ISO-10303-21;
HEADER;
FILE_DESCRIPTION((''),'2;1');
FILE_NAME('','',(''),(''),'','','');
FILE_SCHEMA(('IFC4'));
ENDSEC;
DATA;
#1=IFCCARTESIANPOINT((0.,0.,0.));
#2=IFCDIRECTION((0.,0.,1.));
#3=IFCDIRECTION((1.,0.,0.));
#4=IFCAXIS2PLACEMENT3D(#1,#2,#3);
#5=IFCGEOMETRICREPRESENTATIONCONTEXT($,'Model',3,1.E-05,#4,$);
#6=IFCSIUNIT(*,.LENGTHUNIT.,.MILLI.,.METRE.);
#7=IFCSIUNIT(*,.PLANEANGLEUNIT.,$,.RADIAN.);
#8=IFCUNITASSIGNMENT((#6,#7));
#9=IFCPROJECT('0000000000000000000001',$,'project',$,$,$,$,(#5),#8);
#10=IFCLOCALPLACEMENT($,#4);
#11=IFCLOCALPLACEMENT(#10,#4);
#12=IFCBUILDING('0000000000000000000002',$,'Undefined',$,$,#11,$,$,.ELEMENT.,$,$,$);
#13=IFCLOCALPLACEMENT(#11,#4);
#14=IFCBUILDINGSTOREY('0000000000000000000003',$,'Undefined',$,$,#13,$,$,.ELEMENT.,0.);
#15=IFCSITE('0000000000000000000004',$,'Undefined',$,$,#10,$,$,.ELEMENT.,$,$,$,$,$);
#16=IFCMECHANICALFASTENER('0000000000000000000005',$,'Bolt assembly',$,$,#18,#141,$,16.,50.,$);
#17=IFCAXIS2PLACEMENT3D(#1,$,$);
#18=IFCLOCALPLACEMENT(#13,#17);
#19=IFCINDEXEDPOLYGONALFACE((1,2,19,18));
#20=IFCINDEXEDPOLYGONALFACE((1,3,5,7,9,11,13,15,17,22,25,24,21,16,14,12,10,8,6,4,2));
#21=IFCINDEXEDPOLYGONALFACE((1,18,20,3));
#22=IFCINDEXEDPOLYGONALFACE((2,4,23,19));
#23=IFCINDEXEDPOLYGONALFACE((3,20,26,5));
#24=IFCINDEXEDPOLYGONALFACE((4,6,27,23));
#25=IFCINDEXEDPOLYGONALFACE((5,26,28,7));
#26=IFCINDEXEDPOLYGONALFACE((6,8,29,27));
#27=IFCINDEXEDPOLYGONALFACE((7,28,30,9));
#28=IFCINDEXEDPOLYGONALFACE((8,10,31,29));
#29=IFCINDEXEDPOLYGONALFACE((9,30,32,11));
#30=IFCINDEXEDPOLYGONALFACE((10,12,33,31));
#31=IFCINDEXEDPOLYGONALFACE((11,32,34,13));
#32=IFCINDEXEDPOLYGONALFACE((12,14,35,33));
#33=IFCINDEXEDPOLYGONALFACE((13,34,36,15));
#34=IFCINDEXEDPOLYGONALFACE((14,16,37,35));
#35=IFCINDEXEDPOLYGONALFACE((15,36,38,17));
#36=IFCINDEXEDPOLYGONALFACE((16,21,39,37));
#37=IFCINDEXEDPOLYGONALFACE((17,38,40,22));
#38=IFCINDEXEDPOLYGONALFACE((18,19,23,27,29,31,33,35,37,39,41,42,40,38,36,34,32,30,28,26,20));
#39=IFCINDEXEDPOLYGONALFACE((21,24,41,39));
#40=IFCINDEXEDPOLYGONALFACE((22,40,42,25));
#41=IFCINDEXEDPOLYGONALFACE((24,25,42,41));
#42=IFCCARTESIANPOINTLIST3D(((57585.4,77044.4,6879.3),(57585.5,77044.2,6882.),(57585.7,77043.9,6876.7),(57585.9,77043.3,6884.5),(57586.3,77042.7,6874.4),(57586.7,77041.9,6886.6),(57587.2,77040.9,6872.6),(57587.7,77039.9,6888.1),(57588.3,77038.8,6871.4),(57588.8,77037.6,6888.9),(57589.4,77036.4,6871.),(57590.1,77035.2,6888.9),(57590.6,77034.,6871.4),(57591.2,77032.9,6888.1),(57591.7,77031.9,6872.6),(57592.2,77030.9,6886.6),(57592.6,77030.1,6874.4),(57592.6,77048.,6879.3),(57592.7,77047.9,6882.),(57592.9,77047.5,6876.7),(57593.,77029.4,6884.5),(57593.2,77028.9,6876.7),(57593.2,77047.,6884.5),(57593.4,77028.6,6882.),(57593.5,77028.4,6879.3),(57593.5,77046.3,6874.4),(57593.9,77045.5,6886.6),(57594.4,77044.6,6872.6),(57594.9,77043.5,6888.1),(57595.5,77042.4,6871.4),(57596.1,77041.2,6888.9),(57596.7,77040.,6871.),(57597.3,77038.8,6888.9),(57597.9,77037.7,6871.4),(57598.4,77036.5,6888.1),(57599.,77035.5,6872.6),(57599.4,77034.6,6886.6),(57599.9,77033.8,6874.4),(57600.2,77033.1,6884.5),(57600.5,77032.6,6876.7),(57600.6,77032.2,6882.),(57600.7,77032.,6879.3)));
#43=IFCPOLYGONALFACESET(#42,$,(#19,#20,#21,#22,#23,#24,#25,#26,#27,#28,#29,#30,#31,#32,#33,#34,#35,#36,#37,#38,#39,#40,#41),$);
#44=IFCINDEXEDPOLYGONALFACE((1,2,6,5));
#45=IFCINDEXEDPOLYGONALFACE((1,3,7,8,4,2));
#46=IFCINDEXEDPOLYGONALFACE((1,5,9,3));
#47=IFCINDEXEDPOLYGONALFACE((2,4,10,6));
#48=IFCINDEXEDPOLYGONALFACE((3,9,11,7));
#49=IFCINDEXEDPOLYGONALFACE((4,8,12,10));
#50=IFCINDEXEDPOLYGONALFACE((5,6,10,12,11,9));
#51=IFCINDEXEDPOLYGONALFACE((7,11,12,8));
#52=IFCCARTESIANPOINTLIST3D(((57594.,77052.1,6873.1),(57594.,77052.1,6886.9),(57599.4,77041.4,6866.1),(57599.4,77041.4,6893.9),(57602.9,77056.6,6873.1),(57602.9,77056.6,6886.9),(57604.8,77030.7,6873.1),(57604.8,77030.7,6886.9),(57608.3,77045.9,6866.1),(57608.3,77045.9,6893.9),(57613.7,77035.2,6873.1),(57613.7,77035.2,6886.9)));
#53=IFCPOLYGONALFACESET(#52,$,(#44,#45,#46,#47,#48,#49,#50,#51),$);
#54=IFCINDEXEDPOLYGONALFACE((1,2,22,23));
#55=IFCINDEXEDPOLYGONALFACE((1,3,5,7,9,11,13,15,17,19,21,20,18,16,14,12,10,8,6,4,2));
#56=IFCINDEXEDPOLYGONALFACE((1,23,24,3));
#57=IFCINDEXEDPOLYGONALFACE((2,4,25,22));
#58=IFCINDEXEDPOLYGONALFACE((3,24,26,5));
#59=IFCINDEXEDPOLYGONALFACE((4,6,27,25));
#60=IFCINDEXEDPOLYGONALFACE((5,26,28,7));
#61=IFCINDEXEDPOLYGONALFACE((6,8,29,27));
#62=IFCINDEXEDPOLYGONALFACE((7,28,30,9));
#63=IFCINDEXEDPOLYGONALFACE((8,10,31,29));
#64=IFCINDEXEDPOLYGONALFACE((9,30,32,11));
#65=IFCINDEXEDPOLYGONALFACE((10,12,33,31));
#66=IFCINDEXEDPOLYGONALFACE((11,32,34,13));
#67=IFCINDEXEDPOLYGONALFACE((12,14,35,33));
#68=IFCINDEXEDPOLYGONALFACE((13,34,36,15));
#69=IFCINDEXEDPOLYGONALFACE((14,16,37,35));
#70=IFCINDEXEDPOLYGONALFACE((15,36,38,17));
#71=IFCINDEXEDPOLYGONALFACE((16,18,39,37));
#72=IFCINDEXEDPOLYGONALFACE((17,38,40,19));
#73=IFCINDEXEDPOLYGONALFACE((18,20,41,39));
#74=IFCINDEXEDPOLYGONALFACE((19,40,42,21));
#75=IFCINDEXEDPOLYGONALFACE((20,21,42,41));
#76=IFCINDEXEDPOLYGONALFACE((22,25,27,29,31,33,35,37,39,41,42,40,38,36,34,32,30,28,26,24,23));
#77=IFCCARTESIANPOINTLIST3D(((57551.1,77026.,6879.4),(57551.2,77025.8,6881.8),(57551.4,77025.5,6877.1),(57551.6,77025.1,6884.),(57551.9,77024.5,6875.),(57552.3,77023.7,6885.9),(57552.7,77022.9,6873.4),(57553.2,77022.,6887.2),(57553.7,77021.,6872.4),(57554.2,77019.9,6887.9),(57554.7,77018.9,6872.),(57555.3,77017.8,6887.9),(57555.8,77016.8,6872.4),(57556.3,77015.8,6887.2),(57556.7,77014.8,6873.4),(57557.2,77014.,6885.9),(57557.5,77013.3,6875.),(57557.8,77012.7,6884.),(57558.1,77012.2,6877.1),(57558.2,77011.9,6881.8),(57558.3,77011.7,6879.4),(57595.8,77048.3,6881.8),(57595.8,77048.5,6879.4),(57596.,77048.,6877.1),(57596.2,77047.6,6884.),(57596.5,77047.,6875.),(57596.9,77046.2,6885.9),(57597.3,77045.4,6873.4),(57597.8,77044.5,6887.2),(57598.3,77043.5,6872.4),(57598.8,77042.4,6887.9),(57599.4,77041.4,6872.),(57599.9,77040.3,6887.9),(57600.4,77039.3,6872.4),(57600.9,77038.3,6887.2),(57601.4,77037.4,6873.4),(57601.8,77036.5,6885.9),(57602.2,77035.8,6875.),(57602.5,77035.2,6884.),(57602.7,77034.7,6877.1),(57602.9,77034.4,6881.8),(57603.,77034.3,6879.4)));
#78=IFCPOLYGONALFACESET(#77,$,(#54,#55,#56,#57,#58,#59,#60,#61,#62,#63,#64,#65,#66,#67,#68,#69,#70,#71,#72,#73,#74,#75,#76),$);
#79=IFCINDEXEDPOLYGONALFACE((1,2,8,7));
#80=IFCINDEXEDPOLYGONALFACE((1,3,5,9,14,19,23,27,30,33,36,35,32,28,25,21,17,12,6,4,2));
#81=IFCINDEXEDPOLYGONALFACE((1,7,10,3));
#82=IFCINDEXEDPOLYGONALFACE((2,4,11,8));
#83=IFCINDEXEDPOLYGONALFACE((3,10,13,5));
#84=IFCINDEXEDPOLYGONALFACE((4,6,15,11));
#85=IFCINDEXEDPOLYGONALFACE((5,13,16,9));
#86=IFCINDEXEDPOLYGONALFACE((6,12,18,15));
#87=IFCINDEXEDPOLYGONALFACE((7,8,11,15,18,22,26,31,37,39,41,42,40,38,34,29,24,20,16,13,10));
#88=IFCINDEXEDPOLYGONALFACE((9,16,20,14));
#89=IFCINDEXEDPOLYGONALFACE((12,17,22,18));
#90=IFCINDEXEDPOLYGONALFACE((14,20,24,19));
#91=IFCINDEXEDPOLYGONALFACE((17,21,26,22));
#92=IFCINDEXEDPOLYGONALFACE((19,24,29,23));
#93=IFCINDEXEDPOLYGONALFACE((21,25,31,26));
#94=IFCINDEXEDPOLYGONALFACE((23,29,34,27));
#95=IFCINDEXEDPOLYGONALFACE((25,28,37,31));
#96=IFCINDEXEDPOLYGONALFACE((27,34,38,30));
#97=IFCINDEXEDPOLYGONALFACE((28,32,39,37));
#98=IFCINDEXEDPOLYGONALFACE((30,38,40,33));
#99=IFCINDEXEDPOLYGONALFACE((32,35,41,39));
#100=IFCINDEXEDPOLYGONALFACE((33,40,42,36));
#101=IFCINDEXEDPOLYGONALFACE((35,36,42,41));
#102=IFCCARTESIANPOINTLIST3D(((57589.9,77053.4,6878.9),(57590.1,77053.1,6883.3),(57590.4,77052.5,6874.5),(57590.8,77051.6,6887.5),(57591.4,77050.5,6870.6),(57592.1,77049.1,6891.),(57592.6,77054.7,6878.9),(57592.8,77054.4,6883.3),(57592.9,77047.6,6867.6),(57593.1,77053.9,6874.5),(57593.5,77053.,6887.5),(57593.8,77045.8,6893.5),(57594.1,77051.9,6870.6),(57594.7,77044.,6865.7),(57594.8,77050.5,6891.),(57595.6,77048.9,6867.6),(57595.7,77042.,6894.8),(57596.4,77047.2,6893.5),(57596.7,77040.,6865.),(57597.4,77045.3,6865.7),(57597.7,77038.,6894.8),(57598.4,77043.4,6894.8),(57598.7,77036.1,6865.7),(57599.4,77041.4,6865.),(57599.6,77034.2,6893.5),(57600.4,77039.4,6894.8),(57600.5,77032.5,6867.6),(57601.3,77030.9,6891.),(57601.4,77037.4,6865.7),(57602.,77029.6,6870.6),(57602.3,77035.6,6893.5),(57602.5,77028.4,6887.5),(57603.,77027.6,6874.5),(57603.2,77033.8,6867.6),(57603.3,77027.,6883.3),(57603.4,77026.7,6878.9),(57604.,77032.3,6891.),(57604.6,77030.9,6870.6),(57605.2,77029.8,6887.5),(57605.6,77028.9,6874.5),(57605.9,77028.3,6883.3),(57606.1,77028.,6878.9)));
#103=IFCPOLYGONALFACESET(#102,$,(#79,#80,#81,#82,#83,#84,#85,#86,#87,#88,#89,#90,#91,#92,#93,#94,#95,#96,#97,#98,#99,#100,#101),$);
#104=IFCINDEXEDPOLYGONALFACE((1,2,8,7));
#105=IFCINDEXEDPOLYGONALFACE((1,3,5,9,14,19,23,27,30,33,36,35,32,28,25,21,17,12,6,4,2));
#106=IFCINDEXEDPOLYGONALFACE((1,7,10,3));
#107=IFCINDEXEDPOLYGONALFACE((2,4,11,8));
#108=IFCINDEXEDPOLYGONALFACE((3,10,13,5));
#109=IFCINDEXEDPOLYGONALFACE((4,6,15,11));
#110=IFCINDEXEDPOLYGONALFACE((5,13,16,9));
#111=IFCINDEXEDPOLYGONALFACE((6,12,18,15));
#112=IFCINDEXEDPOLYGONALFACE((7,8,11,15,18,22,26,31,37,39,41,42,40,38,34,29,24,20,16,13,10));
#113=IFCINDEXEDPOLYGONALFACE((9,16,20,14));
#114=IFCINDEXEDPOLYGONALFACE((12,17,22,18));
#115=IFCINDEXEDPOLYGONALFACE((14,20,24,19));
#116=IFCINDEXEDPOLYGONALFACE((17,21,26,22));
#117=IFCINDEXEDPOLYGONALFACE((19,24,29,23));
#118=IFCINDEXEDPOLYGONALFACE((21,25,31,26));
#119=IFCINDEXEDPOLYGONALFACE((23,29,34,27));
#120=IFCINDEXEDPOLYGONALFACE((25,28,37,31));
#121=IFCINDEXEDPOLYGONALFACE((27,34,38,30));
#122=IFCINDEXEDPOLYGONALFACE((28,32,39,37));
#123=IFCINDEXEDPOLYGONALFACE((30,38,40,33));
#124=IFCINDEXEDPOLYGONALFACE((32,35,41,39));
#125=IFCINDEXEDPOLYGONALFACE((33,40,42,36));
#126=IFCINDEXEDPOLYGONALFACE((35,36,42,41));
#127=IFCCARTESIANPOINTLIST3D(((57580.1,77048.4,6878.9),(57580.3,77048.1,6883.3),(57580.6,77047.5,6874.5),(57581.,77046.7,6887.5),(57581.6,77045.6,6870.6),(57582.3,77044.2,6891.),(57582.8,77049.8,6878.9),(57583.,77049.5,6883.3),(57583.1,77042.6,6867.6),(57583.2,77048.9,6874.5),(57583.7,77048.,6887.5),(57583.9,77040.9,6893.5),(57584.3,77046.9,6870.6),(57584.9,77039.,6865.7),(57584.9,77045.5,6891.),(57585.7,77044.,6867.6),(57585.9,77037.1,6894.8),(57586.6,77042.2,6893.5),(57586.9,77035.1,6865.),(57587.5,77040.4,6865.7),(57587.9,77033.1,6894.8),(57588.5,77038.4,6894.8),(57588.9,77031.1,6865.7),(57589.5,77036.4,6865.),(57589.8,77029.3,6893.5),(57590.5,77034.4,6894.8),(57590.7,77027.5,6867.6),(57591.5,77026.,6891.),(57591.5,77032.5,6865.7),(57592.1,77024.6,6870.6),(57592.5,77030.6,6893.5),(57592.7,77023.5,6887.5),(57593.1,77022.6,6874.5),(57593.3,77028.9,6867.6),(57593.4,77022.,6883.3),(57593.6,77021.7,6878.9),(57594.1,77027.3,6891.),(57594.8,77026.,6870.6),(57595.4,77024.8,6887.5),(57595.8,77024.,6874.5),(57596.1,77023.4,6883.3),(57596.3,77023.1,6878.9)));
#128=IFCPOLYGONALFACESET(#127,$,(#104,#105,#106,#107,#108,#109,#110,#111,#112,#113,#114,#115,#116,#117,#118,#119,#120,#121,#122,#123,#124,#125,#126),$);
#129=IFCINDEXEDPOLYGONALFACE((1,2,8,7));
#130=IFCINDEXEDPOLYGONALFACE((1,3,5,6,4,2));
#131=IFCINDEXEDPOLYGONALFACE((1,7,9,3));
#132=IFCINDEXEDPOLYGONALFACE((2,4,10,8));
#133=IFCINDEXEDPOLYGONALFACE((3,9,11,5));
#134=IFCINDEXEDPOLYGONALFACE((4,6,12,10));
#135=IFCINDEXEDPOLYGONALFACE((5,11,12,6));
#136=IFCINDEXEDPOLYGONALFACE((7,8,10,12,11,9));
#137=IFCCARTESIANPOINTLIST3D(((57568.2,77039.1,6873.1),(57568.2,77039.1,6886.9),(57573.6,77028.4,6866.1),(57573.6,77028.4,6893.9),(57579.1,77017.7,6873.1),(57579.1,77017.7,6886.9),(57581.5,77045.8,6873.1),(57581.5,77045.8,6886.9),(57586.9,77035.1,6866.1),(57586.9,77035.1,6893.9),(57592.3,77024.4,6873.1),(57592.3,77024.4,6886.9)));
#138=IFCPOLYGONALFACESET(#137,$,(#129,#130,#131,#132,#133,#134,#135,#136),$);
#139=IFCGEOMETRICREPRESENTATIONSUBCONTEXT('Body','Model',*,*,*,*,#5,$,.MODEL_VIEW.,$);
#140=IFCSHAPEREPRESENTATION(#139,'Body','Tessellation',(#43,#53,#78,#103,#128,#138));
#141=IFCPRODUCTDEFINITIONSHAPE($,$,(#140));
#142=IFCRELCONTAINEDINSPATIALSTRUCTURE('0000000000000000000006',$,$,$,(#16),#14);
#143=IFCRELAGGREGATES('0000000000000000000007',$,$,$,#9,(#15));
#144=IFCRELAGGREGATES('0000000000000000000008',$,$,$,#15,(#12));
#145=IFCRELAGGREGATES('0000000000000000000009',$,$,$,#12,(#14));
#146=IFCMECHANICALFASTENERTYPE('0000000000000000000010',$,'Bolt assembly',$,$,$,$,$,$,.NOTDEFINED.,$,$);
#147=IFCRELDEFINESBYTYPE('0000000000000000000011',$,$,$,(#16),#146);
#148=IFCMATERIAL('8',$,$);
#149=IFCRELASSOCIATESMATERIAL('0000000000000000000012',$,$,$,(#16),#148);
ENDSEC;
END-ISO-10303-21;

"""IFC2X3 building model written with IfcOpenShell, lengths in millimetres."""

from ifc_helpers import new_model, si_unit, frame, origin_with_axes, origin_2d_with_axis, place, context, subcontext, project, spatial, polyline, circle, outline, extrude, source, transform, mapped, material, type_object, element, save


model = new_model("IFC2X3")

# Units and contexts
model_context = context("Model", 3, precision=1e-05, world=origin_with_axes())
body_context = subcontext(model_context, "Body", "Model", "MODEL_VIEW")
ifc_project = project(units=[si_unit("LENGTHUNIT", "METRE", prefix="MILLI"), si_unit("PLANEANGLEUNIT", "RADIAN")], contexts=[model_context])

# Site, building, storey
site_placement = place(None, origin_with_axes())
site = spatial("IfcSite", under=ifc_project, at=site_placement, Name="Undefined", CompositionType="ELEMENT")
building_placement = place(site_placement, origin_with_axes())
building = spatial("IfcBuilding", under=site, at=building_placement, Name="Undefined", CompositionType="ELEMENT")
storey_placement = place(building_placement, origin_with_axes())
storey = spatial("IfcBuildingStorey", under=building, at=storey_placement, Name="Undefined", CompositionType="ELEMENT", Elevation=0.0)

# Mechanical fastener
ifc_material_1 = material(Name="8")
mechanical_fastener_type = type_object("IfcMechanicalFastenerType", Name="Bolt assembly")
shared_shape_1 = source(origin_with_axes(), body_context, "Body", "SweptSolid", [
    extrude(circle(Radius=9.0, at=origin_2d_with_axis()), frame((0.0, 0.0, 0.0), z_axis=(0.0, 1.0, 0.0), x_axis=(1.0, 0.0, 0.0)), (0.0, 0.0, 1.0), 8.1),
    extrude(outline(polyline([(13.9, 0.0), (6.9, 12.0), (-6.9, 12.0), (-13.9, 0.0), (-6.9, -12.0), (6.9, -12.0), (13.9, 0.0)])), frame((0.0, -13.0, 0.0), z_axis=(0.0, 1.0, 0.0), x_axis=(1.0, 0.0, 0.0)), (0.0, 0.0, 1.0), 10.0),
    extrude(circle(Radius=8.0, at=origin_2d_with_axis()), frame((0.0, -3.0, 0.0), z_axis=(0.0, 1.0, 0.0), x_axis=(1.0, 0.0, 0.0)), (0.0, 0.0, 1.0), 50.0),
    extrude(circle(Radius=15.0, at=origin_2d_with_axis()), frame((0.0, -3.0, 0.0), z_axis=(0.0, 1.0, 0.0), x_axis=(1.0, 0.0, 0.0)), (0.0, 0.0, 1.0), 3.0),
    extrude(circle(Radius=15.0, at=origin_2d_with_axis()), frame((0.0, 8.0, 0.0), z_axis=(0.0, 1.0, 0.0), x_axis=(1.0, 0.0, 0.0)), (0.0, 0.0, 1.0), 3.0),
    extrude(outline(polyline([(13.9, 0.0), (6.9, 12.0), (-6.9, 12.0), (-13.9, 0.0), (-6.9, -12.0), (6.9, -12.0), (13.9, 0.0)])), frame((0.0, 11.0, 0.0), z_axis=(0.0, 1.0, 0.0), x_axis=(1.0, 0.0, 0.0)), (0.0, 0.0, 1.0), 14.8),
])
mechanical_fastener_1_placement = place(storey_placement, frame((57596.7, 77040.0, 6880.0), z_axis=(-0.45041, 0.892822, 0.000127), x_axis=(-0.000057, 0.000114, -1.0)))
element("IfcMechanicalFastener", 1, at=mechanical_fastener_1_placement, inside=storey, type_object=mechanical_fastener_type, material=ifc_material_1, Name="Bolt assembly", NominalDiameter=16.0, NominalLength=50.0, context=body_context, shape_type="MappedRepresentation", body=[
    mapped(shared_shape_1, transform((0.0, 0.0, 0.0))),
])

save(model, "model.ifc")
